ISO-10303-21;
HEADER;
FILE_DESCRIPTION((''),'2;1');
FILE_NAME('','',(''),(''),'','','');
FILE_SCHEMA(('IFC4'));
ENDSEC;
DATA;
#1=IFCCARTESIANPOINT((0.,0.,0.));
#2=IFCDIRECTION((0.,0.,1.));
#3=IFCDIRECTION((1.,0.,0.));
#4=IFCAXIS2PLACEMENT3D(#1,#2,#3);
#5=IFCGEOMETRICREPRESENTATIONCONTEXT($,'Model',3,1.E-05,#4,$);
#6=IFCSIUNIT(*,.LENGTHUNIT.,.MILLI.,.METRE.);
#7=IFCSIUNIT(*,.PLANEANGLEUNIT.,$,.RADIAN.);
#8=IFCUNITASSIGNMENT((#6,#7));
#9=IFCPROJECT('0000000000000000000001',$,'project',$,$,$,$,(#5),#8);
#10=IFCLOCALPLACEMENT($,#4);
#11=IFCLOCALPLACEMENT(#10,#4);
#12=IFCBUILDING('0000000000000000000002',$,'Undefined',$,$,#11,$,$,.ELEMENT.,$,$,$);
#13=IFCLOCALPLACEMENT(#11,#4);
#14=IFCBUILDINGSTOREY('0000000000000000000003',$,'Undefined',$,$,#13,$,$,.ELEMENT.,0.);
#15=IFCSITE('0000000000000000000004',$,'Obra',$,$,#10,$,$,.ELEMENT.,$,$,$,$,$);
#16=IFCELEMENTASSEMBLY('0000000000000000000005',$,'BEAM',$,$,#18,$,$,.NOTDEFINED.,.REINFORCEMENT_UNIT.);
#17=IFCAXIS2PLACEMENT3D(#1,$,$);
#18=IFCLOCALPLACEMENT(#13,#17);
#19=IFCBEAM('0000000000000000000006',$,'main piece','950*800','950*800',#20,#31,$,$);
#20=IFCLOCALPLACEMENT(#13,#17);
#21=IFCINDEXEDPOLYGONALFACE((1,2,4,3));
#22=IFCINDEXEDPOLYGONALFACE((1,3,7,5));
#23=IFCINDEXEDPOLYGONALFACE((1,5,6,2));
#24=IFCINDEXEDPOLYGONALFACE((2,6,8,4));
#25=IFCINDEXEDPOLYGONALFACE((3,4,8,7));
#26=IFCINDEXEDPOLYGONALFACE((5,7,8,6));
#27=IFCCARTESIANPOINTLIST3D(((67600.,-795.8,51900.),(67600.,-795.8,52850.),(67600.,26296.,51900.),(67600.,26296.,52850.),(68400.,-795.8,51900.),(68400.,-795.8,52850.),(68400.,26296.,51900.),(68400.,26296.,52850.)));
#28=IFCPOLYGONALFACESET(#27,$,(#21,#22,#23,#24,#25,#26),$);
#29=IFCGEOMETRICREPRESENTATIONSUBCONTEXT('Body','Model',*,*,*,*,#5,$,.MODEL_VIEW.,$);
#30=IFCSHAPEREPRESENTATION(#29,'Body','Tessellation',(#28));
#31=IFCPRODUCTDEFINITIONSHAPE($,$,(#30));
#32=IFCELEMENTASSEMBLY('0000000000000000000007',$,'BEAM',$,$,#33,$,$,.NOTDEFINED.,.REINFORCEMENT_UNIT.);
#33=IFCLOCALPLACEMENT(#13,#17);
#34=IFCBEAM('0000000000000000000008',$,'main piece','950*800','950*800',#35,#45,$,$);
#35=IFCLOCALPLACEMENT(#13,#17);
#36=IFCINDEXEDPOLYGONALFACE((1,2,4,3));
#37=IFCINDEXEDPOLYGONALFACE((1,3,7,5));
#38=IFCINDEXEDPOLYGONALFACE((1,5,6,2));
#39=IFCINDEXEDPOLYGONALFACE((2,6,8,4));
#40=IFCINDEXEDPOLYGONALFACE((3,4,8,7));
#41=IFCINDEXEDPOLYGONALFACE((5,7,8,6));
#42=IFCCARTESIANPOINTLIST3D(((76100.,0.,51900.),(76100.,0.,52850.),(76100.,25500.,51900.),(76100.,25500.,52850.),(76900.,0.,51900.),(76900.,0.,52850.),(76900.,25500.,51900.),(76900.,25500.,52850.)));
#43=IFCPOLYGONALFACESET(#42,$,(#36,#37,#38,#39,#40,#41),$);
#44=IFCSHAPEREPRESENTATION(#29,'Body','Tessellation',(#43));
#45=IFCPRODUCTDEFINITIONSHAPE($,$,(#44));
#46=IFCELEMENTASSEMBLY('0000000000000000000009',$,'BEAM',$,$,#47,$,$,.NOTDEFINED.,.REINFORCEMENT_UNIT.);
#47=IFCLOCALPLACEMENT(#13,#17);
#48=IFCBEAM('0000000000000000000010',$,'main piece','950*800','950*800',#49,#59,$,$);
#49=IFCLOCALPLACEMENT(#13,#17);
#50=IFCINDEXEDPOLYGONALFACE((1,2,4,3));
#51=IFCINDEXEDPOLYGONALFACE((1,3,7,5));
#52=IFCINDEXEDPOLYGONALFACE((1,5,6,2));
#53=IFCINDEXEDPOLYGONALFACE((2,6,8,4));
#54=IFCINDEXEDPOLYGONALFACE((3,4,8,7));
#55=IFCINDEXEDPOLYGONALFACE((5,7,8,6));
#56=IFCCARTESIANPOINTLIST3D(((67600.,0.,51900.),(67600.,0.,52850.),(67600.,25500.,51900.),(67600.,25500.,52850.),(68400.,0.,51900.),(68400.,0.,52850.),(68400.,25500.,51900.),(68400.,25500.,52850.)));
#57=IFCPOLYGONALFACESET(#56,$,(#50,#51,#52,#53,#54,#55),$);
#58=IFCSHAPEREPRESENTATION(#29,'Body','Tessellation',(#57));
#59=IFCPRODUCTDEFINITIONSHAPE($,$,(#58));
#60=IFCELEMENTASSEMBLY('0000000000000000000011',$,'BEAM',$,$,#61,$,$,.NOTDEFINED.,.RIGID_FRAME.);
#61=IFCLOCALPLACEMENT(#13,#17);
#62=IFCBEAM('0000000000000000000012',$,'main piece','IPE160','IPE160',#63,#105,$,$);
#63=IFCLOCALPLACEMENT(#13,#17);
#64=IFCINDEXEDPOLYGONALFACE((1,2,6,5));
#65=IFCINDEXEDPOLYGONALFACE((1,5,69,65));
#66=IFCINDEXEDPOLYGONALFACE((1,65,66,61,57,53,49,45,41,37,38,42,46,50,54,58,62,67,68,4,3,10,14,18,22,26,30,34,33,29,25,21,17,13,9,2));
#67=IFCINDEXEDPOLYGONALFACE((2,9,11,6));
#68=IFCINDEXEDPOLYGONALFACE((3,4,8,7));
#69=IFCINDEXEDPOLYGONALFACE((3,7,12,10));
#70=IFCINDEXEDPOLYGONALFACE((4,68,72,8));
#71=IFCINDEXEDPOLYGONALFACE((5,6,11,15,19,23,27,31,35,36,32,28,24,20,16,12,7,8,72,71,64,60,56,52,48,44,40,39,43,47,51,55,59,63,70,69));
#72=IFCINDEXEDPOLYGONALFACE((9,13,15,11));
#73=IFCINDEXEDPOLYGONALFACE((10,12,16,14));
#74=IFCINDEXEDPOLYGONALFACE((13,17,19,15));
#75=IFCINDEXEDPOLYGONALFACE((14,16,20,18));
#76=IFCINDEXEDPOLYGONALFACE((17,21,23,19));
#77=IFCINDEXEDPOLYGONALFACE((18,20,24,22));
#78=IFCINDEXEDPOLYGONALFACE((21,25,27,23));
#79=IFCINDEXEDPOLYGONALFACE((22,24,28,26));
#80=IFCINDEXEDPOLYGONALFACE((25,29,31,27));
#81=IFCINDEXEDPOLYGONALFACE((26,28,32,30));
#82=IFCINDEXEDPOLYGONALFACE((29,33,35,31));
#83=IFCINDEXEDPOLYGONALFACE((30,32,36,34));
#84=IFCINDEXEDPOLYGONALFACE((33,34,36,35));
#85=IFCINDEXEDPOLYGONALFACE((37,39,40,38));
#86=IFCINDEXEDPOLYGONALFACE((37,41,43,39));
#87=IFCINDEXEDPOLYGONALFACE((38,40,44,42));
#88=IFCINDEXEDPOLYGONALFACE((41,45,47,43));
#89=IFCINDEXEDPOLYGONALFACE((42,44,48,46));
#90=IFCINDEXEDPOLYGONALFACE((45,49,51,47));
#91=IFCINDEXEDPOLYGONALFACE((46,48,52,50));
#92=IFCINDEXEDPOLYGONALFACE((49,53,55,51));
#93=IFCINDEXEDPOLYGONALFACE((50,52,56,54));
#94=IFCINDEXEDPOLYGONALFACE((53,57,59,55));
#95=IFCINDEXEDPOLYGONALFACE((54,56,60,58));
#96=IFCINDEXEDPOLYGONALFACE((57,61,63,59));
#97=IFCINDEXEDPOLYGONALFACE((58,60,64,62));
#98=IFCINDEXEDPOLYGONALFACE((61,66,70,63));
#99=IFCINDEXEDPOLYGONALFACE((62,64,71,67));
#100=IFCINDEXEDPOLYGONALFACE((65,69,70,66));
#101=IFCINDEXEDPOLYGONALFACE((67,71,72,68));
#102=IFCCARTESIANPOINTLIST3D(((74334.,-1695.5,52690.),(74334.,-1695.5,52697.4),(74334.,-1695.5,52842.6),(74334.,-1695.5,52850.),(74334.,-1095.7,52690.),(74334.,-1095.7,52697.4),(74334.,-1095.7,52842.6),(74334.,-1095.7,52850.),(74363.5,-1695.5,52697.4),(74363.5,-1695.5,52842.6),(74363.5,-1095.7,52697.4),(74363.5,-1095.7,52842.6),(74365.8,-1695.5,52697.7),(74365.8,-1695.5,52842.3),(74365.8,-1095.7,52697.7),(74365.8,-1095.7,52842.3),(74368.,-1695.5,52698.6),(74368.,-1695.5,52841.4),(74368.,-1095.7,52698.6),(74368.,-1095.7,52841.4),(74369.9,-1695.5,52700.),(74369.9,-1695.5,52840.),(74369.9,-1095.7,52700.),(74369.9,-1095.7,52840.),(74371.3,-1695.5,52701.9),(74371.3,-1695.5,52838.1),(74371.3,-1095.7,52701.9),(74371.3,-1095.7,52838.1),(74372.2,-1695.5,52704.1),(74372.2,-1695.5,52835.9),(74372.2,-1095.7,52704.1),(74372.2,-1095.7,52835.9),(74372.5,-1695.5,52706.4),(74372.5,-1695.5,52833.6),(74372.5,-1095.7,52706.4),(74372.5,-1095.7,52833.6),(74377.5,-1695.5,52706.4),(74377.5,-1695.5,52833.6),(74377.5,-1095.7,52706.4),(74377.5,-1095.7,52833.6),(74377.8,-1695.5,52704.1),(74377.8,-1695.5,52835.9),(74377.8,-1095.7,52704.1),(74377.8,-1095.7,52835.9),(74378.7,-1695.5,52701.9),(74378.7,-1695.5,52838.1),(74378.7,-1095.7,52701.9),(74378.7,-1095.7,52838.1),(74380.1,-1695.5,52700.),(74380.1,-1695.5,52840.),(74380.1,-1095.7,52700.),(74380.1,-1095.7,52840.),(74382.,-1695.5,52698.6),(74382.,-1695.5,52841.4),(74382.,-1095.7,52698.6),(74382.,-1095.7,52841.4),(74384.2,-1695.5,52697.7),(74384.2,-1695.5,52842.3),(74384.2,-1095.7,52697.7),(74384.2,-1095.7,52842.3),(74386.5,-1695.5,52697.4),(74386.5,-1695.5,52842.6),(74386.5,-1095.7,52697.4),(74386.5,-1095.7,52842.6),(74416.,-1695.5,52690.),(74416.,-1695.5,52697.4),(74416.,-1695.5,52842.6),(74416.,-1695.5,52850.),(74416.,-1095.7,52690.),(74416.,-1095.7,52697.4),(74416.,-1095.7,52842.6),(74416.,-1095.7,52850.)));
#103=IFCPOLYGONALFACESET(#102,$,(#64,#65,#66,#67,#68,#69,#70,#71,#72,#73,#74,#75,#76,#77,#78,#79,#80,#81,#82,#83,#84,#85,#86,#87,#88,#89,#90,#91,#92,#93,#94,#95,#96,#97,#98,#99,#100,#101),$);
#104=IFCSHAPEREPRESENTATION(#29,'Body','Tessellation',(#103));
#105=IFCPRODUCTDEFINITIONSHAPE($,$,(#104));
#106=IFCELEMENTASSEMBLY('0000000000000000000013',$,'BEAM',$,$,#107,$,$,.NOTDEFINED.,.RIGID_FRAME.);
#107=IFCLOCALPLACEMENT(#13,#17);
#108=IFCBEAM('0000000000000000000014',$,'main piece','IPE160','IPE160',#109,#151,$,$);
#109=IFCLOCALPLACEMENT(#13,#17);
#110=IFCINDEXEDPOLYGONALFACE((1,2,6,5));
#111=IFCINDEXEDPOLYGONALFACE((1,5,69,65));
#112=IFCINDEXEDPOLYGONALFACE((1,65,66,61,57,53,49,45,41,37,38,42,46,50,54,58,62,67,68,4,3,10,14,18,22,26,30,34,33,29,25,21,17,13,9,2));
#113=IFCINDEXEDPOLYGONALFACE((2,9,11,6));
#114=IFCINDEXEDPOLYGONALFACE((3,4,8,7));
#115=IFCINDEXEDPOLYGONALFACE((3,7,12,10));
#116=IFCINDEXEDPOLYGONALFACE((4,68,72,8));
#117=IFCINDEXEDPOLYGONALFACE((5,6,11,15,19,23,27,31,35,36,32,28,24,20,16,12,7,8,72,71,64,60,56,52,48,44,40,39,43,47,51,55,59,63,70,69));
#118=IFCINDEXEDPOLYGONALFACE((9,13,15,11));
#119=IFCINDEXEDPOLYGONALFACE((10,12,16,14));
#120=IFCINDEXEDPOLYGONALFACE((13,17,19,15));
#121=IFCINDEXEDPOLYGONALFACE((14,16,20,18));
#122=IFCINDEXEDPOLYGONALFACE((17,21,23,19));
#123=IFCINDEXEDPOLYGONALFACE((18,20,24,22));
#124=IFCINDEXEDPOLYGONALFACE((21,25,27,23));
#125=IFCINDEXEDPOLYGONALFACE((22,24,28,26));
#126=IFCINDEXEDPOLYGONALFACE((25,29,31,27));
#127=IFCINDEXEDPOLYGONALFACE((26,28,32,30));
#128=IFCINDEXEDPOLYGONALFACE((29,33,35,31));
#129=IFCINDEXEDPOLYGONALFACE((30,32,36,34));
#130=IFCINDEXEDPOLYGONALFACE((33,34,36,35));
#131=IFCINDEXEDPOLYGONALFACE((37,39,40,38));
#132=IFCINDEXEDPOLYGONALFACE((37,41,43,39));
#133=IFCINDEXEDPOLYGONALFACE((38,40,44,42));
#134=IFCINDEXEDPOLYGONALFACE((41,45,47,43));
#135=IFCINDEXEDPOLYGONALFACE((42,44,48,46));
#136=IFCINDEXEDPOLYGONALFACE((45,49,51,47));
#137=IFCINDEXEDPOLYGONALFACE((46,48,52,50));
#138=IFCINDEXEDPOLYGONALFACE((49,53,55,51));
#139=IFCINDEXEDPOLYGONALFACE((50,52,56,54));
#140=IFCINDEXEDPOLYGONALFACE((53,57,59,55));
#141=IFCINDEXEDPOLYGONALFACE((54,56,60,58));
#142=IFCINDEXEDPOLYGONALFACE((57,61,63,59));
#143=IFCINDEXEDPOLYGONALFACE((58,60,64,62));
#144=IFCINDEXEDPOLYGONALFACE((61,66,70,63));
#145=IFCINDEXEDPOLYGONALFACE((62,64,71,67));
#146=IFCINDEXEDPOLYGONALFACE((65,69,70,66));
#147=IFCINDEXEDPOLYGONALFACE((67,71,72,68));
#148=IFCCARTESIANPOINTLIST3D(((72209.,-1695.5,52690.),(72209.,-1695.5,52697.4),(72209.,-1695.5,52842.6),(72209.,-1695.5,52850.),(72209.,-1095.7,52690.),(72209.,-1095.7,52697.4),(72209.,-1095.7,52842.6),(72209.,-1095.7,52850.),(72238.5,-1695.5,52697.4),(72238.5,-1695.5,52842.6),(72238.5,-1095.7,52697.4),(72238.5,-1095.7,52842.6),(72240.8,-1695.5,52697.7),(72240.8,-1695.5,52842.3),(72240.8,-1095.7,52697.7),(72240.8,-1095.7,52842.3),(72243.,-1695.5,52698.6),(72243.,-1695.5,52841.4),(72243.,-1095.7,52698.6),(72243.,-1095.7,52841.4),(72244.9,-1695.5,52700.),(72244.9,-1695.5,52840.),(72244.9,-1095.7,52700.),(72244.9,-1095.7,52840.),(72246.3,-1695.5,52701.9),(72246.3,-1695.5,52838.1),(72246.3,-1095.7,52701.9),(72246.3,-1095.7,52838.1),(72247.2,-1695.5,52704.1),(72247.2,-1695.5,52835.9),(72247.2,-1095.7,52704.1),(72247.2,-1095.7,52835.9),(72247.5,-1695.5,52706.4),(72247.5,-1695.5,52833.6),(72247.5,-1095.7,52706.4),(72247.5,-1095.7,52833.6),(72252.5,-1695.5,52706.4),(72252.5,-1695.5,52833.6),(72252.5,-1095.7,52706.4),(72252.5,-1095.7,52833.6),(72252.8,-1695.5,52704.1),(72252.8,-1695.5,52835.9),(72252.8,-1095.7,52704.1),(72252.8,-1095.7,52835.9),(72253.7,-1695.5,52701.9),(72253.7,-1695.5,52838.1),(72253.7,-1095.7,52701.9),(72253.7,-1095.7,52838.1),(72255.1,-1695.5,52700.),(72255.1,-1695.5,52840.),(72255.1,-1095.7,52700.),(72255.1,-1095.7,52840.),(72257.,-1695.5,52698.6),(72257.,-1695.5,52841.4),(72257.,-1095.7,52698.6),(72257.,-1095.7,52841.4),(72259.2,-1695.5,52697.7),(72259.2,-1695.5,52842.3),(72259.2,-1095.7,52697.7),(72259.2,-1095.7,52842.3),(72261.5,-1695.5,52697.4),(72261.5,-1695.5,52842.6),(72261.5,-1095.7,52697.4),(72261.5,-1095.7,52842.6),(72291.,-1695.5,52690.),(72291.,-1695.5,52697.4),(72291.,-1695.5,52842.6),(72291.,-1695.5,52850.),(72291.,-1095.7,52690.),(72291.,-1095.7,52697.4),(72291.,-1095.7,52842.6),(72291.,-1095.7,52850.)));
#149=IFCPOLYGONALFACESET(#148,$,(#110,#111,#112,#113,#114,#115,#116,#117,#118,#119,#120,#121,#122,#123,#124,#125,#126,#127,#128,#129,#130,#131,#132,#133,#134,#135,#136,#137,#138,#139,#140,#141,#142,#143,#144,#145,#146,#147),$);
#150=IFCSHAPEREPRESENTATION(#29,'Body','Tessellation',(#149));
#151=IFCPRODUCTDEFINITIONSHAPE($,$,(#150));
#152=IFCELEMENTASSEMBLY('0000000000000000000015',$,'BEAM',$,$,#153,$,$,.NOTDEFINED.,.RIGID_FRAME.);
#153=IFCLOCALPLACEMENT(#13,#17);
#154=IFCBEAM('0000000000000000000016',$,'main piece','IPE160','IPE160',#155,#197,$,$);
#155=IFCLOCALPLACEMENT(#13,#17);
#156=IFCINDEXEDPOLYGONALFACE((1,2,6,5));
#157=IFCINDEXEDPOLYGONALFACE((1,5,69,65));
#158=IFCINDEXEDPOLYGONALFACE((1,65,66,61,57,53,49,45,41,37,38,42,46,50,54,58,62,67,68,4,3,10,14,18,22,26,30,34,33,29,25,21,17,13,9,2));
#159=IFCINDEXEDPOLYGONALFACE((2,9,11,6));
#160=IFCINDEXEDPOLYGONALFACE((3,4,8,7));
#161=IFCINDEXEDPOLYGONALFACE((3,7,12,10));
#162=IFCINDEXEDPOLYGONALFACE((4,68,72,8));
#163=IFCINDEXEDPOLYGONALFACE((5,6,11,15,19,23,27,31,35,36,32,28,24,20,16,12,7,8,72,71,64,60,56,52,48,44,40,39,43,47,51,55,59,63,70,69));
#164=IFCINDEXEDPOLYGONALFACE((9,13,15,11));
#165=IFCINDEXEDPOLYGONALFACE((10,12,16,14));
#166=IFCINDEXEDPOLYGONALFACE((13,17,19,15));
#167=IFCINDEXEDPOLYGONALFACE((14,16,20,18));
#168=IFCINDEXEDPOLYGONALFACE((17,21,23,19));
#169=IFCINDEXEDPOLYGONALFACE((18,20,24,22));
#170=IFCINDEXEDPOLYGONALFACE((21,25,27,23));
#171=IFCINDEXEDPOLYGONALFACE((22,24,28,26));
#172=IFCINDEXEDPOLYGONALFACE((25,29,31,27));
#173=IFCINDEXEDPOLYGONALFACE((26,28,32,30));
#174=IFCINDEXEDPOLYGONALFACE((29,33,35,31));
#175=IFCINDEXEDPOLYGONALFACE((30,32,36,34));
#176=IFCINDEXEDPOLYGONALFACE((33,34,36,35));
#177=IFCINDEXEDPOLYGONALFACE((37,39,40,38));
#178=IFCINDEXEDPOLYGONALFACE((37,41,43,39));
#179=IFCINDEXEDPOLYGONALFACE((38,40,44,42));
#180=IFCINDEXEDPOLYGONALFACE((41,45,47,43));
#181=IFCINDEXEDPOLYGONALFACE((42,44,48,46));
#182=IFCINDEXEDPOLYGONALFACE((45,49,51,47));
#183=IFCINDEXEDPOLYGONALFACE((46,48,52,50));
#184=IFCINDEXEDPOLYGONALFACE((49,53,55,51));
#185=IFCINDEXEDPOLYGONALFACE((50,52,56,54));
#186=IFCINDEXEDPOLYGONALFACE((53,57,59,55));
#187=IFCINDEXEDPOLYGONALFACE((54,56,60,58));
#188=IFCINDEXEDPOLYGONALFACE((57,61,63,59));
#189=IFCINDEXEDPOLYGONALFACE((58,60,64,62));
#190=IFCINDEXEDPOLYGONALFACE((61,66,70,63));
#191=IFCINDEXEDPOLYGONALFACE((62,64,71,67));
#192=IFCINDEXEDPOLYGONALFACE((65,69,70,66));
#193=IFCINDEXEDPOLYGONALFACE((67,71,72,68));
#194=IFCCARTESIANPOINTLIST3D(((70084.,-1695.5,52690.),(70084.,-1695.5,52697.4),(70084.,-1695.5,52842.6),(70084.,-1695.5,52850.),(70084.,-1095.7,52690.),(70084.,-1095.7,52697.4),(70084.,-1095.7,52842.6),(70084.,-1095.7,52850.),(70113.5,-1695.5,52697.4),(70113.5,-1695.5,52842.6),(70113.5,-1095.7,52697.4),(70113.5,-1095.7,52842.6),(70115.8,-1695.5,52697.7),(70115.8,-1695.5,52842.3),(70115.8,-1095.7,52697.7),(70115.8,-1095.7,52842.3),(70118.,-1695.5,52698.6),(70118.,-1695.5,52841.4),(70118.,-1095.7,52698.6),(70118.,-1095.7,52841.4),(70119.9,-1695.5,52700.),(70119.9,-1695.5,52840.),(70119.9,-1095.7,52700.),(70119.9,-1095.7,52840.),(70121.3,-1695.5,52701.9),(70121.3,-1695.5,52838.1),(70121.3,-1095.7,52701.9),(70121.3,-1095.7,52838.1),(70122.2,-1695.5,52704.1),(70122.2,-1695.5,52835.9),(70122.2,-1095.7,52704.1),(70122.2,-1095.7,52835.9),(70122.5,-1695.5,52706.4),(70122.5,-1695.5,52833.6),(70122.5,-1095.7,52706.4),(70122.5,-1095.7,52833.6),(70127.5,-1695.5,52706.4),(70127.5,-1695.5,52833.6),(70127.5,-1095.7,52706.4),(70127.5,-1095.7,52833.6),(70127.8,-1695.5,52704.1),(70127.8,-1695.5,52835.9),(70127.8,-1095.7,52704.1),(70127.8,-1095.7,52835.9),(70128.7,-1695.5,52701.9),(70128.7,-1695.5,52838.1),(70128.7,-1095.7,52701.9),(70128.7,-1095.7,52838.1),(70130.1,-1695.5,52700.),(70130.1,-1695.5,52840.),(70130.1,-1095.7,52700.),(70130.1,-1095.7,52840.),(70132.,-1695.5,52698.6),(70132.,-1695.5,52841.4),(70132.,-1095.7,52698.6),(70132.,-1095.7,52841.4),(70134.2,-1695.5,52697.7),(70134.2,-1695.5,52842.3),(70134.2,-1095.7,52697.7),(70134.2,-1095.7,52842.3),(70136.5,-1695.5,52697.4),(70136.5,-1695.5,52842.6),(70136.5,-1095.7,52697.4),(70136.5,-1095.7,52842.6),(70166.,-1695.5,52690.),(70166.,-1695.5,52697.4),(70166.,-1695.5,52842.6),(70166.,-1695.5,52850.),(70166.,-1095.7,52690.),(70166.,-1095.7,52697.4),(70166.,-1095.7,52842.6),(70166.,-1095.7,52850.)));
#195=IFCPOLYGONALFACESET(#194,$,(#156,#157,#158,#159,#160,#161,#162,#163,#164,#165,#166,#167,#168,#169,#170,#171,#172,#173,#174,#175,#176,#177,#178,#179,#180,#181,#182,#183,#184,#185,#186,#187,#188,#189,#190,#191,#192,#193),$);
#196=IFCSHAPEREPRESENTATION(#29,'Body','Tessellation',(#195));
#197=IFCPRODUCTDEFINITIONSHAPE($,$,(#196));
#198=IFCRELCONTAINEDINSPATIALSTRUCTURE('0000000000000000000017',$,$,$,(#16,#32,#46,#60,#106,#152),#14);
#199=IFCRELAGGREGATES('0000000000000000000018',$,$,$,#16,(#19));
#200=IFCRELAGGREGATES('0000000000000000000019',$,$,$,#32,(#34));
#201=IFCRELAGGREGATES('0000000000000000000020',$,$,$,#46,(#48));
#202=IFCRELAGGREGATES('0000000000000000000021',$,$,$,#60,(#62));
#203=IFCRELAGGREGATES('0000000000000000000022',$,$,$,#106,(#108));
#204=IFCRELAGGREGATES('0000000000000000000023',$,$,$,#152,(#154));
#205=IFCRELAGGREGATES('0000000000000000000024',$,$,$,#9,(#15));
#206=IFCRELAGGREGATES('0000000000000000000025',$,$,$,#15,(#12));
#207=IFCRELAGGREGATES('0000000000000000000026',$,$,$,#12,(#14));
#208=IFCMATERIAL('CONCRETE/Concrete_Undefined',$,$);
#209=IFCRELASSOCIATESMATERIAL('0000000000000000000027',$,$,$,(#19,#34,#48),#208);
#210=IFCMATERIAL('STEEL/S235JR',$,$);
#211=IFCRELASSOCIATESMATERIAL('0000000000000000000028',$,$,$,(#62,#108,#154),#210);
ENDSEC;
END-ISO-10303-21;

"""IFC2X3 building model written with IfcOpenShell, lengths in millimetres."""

from ifc_helpers import new_model, si_unit, frame, origin_with_axes, origin_2d_with_axis, place, context, subcontext, project, spatial, rectangle, i_section, extrude, material, element, aggregate, save


model = new_model("IFC2X3")

# Units and contexts
model_context = context("Model", 3, precision=1e-05, world=origin_with_axes())
body_context = subcontext(model_context, "Body", "Model", "MODEL_VIEW")
ifc_project = project(units=[si_unit("LENGTHUNIT", "METRE", prefix="MILLI"), si_unit("PLANEANGLEUNIT", "RADIAN")], contexts=[model_context])

# Site, building, storey
site_placement = place(None, origin_with_axes())
site = spatial("IfcSite", under=ifc_project, at=site_placement, Name="Obra", CompositionType="ELEMENT")
building_placement = place(site_placement, origin_with_axes())
building = spatial("IfcBuilding", under=site, at=building_placement, Name="Undefined", CompositionType="ELEMENT")
storey_placement = place(building_placement, origin_with_axes())
storey = spatial("IfcBuildingStorey", under=building, at=storey_placement, Name="Undefined", CompositionType="ELEMENT", Elevation=0.0)

# Shared definitions
ifc_material_1 = material(Name="STEEL/S235JR")

# Element assemblies, beams
ifc_material_2 = material(Name="CONCRETE/Concrete_Undefined")
assembly_1_placement = place(storey_placement, origin_with_axes())
assembly_1 = element("IfcElementAssembly", 1, at=assembly_1_placement, inside=storey, Name="BEAM", AssemblyPlace="NOTDEFINED", PredefinedType="REINFORCEMENT_UNIT")
beam_1_placement = place(assembly_1_placement, frame((68000.0, -795.8, 52375.0), z_axis=(0.0, 0.0, 1.0), x_axis=(0.0, 1.0, 0.0)))
beam_1 = element("IfcBeam", 2, at=beam_1_placement, material=ifc_material_2, Name="main piece", Description="950*800", ObjectType="950*800", context=body_context, shape_type="SweptSolid", body=[
    extrude(rectangle(XDim=800.0, YDim=950.0, at=origin_2d_with_axis()), frame((27091.8, 0.0, 0.0), z_axis=(-1.0, 0.0, 0.0), x_axis=(0.0, -1.0, 0.0)), (0.0, 0.0, 1.0), 27091.8),
])
aggregate(assembly_1, [beam_1])
assembly_2_placement = place(storey_placement, origin_with_axes())
assembly_2 = element("IfcElementAssembly", 3, at=assembly_2_placement, inside=storey, Name="BEAM", AssemblyPlace="NOTDEFINED", PredefinedType="REINFORCEMENT_UNIT")
beam_2_placement = place(assembly_2_placement, frame((76500.0, 0.0, 52375.0), z_axis=(0.0, 0.0, 1.0), x_axis=(0.0, 1.0, 0.0)))
beam_2 = element("IfcBeam", 4, at=beam_2_placement, material=ifc_material_2, Name="main piece", Description="950*800", ObjectType="950*800", context=body_context, shape_type="SweptSolid", body=[
    extrude(rectangle(XDim=800.0, YDim=950.0, at=origin_2d_with_axis()), frame((25500.0, 0.0, 0.0), z_axis=(-1.0, 0.0, 0.0), x_axis=(0.0, -1.0, 0.0)), (0.0, 0.0, 1.0), 25500.0),
])
aggregate(assembly_2, [beam_2])
assembly_3_placement = place(storey_placement, origin_with_axes())
assembly_3 = element("IfcElementAssembly", 5, at=assembly_3_placement, inside=storey, Name="BEAM", AssemblyPlace="NOTDEFINED", PredefinedType="REINFORCEMENT_UNIT")
beam_3_placement = place(assembly_3_placement, frame((68000.0, 0.0, 52375.0), z_axis=(0.0, 0.0, 1.0), x_axis=(0.0, 1.0, 0.0)))
beam_3 = element("IfcBeam", 6, at=beam_3_placement, material=ifc_material_2, Name="main piece", Description="950*800", ObjectType="950*800", context=body_context, shape_type="SweptSolid", body=[
    extrude(rectangle(XDim=800.0, YDim=950.0, at=origin_2d_with_axis()), frame((25500.0, 0.0, 0.0), z_axis=(-1.0, 0.0, 0.0), x_axis=(0.0, -1.0, 0.0)), (0.0, 0.0, 1.0), 25500.0),
])
aggregate(assembly_3, [beam_3])
assembly_4_placement = place(storey_placement, origin_with_axes())
assembly_4 = element("IfcElementAssembly", 7, at=assembly_4_placement, inside=storey, Name="BEAM", AssemblyPlace="NOTDEFINED", PredefinedType="RIGID_FRAME")
beam_4_placement = place(assembly_4_placement, frame((74375.0, -1095.7, 52770.0), z_axis=(0.0, 0.0, 1.0), x_axis=(0.0, -1.0, 0.0)))
beam_4 = element("IfcBeam", 8, at=beam_4_placement, material=ifc_material_1, Name="main piece", Description="IPE160", ObjectType="IPE160", context=body_context, shape_type="SweptSolid", body=[
    extrude(i_section(OverallWidth=82.0, OverallDepth=160.0, WebThickness=5.0, FlangeThickness=7.4, FilletRadius=9.0, at=origin_2d_with_axis()), frame((599.8, 0.0, 0.0), z_axis=(-1.0, 0.0, 0.0), x_axis=(0.0, -1.0, 0.0)), (0.0, 0.0, 1.0), 599.8),
])
aggregate(assembly_4, [beam_4])
assembly_5_placement = place(storey_placement, origin_with_axes())
assembly_5 = element("IfcElementAssembly", 9, at=assembly_5_placement, inside=storey, Name="BEAM", AssemblyPlace="NOTDEFINED", PredefinedType="RIGID_FRAME")
beam_5_placement = place(assembly_5_placement, frame((72250.0, -1095.7, 52770.0), z_axis=(0.0, 0.0, 1.0), x_axis=(0.0, -1.0, 0.0)))
beam_5 = element("IfcBeam", 10, at=beam_5_placement, material=ifc_material_1, Name="main piece", Description="IPE160", ObjectType="IPE160", context=body_context, shape_type="SweptSolid", body=[
    extrude(i_section(OverallWidth=82.0, OverallDepth=160.0, WebThickness=5.0, FlangeThickness=7.4, FilletRadius=9.0, at=origin_2d_with_axis()), frame((599.8, 0.0, 0.0), z_axis=(-1.0, 0.0, 0.0), x_axis=(0.0, -1.0, 0.0)), (0.0, 0.0, 1.0), 599.8),
])
aggregate(assembly_5, [beam_5])
assembly_6_placement = place(storey_placement, origin_with_axes())
assembly_6 = element("IfcElementAssembly", 11, at=assembly_6_placement, inside=storey, Name="BEAM", AssemblyPlace="NOTDEFINED", PredefinedType="RIGID_FRAME")
beam_6_placement = place(assembly_6_placement, frame((70125.0, -1695.5, 52770.0), z_axis=(0.0, 0.0, 1.0), x_axis=(0.0, 1.0, 0.0)))
beam_6 = element("IfcBeam", 12, at=beam_6_placement, material=ifc_material_1, Name="main piece", Description="IPE160", ObjectType="IPE160", context=body_context, shape_type="SweptSolid", body=[
    extrude(i_section(OverallWidth=82.0, OverallDepth=160.0, WebThickness=5.0, FlangeThickness=7.4, FilletRadius=9.0, at=origin_2d_with_axis()), frame((599.8, 0.0, 0.0), z_axis=(-1.0, 0.0, 0.0), x_axis=(0.0, -1.0, 0.0)), (0.0, 0.0, 1.0), 599.8),
])
aggregate(assembly_6, [beam_6])

save(model, "model.ifc")
